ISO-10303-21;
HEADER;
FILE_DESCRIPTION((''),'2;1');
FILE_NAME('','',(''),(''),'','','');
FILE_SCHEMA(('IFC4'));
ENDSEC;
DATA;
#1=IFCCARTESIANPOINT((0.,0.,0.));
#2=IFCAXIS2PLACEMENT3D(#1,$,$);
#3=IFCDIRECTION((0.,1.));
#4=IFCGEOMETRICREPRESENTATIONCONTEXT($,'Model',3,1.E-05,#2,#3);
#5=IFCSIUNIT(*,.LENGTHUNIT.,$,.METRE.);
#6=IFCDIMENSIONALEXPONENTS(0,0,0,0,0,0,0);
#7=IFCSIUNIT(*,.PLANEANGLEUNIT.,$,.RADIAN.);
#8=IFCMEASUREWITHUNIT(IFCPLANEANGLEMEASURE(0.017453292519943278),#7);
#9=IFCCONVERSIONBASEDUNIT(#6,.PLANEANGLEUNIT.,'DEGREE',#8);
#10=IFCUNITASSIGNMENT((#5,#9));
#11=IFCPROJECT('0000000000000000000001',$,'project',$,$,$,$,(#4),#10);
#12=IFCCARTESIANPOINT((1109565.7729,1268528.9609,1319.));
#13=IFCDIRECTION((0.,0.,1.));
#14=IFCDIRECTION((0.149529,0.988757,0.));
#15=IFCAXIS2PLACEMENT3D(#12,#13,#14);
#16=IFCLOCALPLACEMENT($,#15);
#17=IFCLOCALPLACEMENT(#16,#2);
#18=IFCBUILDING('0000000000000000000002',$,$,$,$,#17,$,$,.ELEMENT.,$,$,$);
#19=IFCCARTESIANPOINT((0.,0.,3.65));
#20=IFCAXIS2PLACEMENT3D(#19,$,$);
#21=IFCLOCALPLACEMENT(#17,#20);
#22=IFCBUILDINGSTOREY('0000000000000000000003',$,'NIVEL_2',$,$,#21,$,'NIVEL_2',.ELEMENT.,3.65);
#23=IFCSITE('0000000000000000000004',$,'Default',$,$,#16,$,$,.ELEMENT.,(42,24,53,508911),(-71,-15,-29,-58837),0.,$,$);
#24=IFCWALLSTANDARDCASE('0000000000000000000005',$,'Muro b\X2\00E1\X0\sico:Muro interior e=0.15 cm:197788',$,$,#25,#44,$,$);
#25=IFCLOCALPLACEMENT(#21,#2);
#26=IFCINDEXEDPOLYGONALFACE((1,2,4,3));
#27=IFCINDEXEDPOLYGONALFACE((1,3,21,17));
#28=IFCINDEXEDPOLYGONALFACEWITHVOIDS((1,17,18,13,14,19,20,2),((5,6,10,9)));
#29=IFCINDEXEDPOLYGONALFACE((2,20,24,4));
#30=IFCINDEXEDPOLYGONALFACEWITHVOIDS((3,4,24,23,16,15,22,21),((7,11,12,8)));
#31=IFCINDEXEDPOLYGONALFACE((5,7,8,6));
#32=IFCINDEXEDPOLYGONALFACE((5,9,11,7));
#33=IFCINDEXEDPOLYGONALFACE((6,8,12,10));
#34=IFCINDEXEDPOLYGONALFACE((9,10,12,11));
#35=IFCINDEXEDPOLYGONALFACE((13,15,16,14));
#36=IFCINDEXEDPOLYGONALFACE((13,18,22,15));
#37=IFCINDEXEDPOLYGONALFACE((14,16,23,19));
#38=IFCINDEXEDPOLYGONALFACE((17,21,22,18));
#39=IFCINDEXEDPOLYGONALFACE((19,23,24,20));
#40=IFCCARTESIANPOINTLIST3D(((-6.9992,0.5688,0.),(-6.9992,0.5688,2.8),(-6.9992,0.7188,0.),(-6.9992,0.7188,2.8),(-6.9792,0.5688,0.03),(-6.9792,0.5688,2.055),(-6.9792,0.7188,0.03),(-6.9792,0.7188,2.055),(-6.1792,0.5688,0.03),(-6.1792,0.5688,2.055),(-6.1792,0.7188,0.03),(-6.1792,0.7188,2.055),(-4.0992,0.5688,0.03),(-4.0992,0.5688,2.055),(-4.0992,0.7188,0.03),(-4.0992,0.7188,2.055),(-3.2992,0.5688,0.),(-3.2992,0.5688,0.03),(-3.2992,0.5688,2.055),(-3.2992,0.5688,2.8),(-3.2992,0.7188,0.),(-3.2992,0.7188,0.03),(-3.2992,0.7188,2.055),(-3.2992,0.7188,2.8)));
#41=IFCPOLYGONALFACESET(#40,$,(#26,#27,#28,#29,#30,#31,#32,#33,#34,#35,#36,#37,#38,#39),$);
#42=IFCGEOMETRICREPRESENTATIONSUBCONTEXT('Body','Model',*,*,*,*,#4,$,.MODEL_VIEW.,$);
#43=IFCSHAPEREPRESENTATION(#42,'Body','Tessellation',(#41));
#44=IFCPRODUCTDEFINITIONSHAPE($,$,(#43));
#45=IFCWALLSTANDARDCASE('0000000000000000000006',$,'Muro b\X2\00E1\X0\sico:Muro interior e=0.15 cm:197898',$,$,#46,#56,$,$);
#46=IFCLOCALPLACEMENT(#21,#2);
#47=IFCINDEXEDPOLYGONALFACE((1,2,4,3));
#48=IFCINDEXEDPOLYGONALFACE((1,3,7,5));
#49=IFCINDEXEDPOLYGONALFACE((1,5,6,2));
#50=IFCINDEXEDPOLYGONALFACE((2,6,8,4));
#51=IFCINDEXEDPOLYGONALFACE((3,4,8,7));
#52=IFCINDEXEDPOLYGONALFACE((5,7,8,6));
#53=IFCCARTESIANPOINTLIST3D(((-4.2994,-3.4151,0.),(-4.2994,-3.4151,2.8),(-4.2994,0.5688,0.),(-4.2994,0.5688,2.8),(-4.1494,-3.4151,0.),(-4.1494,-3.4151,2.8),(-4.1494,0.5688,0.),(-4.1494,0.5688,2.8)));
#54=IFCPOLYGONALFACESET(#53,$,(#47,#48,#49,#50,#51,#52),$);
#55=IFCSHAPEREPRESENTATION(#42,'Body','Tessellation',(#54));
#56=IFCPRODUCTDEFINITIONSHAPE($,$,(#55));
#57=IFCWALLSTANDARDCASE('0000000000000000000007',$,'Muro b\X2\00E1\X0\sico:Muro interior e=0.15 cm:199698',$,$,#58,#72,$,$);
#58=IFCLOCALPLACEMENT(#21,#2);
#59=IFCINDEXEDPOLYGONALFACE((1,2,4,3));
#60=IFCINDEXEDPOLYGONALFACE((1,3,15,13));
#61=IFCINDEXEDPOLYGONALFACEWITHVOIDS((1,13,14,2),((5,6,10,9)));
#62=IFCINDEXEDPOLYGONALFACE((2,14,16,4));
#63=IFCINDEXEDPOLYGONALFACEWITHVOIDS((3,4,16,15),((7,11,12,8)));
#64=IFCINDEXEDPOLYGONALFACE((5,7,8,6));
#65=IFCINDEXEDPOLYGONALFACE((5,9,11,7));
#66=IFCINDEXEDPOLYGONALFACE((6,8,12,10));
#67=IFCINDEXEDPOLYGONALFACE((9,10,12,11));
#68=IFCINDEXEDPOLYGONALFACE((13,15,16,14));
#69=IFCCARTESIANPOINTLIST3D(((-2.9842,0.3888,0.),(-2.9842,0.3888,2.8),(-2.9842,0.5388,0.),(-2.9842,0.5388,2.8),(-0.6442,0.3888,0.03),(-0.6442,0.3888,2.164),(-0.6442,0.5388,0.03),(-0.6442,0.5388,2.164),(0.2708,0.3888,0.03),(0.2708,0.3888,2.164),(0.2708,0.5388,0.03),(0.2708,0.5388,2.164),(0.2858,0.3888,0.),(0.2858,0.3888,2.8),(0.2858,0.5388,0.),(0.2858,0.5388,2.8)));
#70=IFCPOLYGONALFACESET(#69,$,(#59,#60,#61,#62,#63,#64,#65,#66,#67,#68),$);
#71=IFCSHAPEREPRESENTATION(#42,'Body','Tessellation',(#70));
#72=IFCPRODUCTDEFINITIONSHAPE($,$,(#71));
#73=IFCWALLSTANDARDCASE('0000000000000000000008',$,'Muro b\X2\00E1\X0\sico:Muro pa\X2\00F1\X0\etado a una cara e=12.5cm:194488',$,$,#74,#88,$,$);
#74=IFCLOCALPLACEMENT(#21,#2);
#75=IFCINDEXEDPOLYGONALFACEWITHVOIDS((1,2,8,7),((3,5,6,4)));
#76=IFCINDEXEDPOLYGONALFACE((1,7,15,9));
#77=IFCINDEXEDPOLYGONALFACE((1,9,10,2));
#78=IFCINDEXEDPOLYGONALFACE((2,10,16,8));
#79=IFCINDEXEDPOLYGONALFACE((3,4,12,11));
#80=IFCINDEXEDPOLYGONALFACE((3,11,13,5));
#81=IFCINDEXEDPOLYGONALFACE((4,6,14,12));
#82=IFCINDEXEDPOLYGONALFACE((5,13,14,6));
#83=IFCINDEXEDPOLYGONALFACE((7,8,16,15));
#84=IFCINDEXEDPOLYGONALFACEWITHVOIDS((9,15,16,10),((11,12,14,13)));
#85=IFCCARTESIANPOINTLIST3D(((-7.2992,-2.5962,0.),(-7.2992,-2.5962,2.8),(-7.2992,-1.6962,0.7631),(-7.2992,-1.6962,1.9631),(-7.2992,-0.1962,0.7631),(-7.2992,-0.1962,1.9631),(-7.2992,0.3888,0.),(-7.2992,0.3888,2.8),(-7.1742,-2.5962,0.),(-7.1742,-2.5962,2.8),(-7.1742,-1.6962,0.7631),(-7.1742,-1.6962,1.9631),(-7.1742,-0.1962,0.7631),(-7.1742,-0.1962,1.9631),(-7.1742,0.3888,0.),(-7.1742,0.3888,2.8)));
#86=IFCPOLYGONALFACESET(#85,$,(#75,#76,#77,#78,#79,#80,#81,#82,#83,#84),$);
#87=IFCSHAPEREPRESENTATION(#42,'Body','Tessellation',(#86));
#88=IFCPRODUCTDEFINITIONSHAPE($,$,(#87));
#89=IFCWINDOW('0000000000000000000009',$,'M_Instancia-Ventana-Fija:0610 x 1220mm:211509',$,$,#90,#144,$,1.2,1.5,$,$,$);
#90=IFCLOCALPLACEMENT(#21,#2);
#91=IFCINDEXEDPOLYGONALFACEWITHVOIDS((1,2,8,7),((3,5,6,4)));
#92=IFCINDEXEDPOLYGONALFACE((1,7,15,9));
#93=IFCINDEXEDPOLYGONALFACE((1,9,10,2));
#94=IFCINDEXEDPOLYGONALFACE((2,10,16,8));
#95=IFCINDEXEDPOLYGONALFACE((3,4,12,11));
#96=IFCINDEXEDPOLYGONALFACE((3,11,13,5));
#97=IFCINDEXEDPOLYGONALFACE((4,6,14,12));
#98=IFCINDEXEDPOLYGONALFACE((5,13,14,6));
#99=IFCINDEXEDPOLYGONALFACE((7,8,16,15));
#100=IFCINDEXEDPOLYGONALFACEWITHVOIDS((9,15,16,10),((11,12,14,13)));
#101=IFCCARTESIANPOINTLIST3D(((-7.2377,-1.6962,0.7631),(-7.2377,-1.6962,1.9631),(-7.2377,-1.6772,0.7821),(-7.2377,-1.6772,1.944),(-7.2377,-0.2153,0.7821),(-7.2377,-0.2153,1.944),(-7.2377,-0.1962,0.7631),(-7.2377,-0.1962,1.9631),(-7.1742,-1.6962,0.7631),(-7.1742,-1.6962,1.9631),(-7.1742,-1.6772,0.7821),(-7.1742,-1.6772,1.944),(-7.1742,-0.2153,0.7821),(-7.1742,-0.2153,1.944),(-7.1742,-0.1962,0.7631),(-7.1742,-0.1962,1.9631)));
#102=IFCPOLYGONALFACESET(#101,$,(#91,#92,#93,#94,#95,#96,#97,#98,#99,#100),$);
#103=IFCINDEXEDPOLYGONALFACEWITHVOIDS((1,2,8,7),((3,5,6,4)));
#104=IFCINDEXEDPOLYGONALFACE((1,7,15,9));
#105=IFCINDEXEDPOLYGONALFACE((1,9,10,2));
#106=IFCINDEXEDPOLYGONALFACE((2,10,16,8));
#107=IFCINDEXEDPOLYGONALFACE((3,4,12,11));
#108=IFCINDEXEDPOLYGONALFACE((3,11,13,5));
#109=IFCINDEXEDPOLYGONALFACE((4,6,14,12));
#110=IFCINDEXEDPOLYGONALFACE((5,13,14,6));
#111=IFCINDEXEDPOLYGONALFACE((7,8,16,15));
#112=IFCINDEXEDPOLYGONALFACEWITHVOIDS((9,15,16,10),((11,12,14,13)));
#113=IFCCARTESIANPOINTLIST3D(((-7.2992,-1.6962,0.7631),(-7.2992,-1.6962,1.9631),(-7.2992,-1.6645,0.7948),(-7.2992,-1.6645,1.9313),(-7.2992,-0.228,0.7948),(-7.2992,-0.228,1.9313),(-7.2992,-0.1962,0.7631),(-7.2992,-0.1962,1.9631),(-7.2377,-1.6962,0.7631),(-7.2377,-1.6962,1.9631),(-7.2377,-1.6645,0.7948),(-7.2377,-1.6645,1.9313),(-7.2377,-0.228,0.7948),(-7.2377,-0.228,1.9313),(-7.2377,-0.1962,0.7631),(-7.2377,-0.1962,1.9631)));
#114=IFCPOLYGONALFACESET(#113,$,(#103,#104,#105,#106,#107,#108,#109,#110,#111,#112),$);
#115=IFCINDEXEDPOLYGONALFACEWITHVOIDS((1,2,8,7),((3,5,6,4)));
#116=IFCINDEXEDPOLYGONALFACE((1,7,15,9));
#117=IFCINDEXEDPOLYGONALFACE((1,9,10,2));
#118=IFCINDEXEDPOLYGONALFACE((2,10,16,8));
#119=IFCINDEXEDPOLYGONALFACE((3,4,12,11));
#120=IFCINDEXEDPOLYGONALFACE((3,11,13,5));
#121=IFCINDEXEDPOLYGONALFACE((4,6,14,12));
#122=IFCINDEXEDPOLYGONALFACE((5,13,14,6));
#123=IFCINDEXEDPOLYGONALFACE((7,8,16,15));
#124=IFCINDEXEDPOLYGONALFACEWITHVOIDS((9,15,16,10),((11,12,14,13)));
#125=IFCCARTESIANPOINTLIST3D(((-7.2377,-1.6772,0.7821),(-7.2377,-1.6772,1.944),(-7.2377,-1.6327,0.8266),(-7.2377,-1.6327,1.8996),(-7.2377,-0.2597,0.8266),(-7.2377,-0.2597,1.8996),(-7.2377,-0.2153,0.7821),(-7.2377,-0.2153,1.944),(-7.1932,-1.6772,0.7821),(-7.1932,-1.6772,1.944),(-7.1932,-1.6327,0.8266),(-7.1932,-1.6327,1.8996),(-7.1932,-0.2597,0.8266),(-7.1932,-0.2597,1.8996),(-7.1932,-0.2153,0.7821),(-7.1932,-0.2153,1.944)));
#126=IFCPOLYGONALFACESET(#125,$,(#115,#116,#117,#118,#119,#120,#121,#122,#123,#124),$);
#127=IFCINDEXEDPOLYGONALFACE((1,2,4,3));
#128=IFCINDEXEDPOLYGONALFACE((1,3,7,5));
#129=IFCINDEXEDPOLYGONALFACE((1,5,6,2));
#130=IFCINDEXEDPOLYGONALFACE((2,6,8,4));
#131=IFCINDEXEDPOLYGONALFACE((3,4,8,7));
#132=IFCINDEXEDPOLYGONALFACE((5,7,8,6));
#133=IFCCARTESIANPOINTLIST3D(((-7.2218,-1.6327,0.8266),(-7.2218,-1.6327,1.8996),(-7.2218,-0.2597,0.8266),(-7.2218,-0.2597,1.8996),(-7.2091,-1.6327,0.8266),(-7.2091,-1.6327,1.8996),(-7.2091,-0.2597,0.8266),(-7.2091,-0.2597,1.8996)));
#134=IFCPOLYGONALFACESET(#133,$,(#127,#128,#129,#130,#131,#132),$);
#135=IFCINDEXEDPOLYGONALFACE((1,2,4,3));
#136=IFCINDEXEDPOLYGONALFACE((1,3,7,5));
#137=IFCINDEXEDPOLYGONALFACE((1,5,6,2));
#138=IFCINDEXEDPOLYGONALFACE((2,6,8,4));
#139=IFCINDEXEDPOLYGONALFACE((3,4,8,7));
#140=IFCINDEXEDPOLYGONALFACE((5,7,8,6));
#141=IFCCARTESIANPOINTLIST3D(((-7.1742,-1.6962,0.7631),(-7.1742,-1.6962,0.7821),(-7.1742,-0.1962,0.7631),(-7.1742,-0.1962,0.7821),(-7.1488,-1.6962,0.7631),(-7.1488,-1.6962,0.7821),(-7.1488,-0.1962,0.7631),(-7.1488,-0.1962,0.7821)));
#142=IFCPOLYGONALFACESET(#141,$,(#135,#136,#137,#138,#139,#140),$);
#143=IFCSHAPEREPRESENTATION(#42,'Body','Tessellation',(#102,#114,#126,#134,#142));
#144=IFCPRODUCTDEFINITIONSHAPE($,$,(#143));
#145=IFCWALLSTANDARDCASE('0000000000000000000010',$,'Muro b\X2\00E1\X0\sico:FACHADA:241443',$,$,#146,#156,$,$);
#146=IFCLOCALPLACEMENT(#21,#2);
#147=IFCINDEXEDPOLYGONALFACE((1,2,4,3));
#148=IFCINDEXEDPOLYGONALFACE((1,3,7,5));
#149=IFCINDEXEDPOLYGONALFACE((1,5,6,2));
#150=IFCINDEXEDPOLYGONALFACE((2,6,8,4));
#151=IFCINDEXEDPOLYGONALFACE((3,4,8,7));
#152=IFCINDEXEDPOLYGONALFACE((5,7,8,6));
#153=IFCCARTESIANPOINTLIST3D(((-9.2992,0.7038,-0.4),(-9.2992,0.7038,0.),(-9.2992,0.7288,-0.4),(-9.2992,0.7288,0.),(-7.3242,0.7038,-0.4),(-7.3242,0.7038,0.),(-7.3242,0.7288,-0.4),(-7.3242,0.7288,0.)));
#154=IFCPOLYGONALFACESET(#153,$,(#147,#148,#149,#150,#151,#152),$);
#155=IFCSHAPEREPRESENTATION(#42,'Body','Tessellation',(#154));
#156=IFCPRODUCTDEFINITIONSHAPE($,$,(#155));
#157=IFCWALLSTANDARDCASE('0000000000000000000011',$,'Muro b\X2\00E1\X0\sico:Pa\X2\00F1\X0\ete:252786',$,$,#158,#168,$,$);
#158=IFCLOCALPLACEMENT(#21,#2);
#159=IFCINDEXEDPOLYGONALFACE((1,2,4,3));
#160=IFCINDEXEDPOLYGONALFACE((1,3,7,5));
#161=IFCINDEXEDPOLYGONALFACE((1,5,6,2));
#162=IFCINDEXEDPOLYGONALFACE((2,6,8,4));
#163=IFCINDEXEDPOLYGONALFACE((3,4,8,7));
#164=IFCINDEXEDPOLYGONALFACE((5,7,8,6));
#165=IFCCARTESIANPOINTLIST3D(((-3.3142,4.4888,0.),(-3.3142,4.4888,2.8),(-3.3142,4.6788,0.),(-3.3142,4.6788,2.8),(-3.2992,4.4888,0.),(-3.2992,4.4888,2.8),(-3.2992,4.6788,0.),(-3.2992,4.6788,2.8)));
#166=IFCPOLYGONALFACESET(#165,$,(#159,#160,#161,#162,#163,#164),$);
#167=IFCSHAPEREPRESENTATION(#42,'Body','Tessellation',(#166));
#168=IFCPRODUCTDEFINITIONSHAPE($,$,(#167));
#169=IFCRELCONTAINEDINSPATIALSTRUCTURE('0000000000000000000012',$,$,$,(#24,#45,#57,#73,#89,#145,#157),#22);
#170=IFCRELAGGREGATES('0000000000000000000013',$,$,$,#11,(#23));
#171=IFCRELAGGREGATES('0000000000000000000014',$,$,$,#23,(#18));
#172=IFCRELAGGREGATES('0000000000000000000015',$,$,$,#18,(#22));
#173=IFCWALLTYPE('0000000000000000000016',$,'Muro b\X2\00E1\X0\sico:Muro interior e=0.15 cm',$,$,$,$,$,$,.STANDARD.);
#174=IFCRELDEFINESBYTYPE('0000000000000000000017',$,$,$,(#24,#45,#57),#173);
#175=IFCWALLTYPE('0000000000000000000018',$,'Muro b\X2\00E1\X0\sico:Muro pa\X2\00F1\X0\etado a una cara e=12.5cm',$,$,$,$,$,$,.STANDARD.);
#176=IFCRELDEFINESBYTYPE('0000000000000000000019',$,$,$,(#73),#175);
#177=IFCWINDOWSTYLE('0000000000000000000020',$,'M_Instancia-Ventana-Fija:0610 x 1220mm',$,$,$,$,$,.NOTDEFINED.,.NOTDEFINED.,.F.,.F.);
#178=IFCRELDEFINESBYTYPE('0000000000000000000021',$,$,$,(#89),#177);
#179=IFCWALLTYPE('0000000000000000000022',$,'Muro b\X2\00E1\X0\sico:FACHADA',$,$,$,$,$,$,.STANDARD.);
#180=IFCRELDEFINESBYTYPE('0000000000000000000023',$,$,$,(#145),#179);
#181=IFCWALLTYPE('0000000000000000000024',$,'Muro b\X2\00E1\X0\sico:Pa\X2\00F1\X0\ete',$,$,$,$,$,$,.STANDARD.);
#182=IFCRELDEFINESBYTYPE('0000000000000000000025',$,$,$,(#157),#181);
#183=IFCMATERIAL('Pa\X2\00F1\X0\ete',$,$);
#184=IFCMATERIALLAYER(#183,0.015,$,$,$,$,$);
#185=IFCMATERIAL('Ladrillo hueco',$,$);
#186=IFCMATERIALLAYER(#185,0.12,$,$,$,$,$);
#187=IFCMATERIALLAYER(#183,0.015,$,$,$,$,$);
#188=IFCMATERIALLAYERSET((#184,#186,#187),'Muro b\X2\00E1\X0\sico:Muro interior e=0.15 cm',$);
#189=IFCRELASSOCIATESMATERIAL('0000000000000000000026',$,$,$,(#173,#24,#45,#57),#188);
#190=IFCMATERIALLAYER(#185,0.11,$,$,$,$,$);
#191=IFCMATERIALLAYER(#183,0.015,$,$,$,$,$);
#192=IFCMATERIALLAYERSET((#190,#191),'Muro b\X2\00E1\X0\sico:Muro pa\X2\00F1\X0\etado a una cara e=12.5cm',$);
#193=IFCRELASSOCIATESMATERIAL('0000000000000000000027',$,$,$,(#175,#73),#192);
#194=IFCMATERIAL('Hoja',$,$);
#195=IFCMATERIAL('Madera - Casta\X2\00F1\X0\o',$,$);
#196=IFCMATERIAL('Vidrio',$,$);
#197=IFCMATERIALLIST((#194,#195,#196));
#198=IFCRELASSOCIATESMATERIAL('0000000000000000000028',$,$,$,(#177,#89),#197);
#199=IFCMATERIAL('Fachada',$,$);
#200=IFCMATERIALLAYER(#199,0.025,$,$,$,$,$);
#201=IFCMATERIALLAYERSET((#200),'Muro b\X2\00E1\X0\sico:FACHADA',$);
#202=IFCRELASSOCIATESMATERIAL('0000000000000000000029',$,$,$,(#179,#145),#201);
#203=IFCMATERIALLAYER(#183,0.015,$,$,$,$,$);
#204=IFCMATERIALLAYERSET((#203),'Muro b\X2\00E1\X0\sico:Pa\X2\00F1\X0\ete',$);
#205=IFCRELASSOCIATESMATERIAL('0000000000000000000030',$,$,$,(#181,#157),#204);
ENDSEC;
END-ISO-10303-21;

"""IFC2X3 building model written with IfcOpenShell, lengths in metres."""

from ifc_helpers import new_model, entity, si_unit, converted_unit, direction, frame, frame_2d, origin, origin_2d_with_axis, place, context, subcontext, project, spatial, polyline, rectangle, outline, extrude, source, transform, mapped, material, material_list, layer, layer_set, layer_usage, type_object, type_shapes, element, fill, save


model = new_model("IFC2X3")

# Units and contexts
model_context = context("Model", 3, precision=1e-05, world=origin(), true_north=direction((0.0, 1.0)))
body_context = subcontext(model_context, "Body", "Model", "MODEL_VIEW")
ifc_project = project(units=[si_unit("LENGTHUNIT", "METRE"), converted_unit("PLANEANGLEUNIT", "DEGREE", entity("IfcPlaneAngleMeasure", 0.017453292519943278), si_unit("PLANEANGLEUNIT", "RADIAN"), dimensions=[0, 0, 0, 0, 0, 0, 0])], contexts=[model_context])

# Site, building, storey
site_placement = place(None, frame((1109565.7729, 1268528.9609, 1319.0), z_axis=(0.0, 0.0, 1.0), x_axis=(0.149529, 0.988757, 0.0)))
site = spatial("IfcSite", under=ifc_project, at=site_placement, Name="Default", CompositionType="ELEMENT", RefLatitude=(42, 24, 53, 508911), RefLongitude=(-71, -15, -29, -58837), RefElevation=0.0)
building_placement = place(site_placement, origin())
building = spatial("IfcBuilding", under=site, at=building_placement, CompositionType="ELEMENT")
storey_placement = place(building_placement, frame((0.0, 0.0, 3.65)))
storey = spatial("IfcBuildingStorey", under=building, at=storey_placement, Name="NIVEL_2", LongName="NIVEL_2", CompositionType="ELEMENT", Elevation=3.65)

# Wall, openings
ifc_material_1 = material(Name="Pañete")
ifc_layer_1 = layer(ifc_material_1, 0.015)
ifc_material_2 = material(Name="Ladrillo hueco")
ifc_layer_2 = layer(ifc_material_2, 0.12)
ifc_layer_3 = layer(ifc_material_1, 0.015)
ifc_layer_set_1 = layer_set([ifc_layer_1, ifc_layer_2, ifc_layer_3], Name="Muro básico:Muro interior e=0.15 cm")
ifc_layer_usage_1 = layer_usage(ifc_layer_set_1, "AXIS2", "NEGATIVE", 0.075)
wall_type_1 = type_object("IfcWallType", Name="Muro básico:Muro interior e=0.15 cm", PredefinedType="STANDARD", material=ifc_layer_set_1)
wall_1_placement = place(storey_placement, frame((-6.9992, 0.6438, 0.0)))
wall_1 = element("IfcWallStandardCase", 1, at=wall_1_placement, inside=storey, type_object=wall_type_1, material=ifc_layer_usage_1, Name="Muro básico:Muro interior e=0.15 cm:197788", context=body_context, shape_type="SweptSolid", body=[
    extrude(rectangle(XDim=3.7, YDim=0.15, at=frame_2d((1.85, 0.0), x_axis=(-1.0, 0.0))), origin(), (0.0, 0.0, 1.0), 2.8),
])
opening_1_placement = place(wall_1_placement, frame((2.9, -0.075, 0.03)))
element("IfcOpeningElement", 2, at=opening_1_placement, cuts=wall_1, ObjectType="Opening", context=body_context, shape_type="SweptSolid", body=[
    extrude(rectangle(XDim=2.025, YDim=0.8, at=frame_2d((1.0125, 0.4), x_axis=(1.0, 0.0))), frame((0.0, 0.0, 0.0), z_axis=(0.0, 1.0, 0.0), x_axis=(0.0, 0.0, 1.0)), (0.0, 0.0, 1.0), 0.15),
])
opening_2_placement = place(wall_1_placement, frame((0.82, 0.075, 0.03)))
element("IfcOpeningElement", 3, at=opening_2_placement, cuts=wall_1, ObjectType="Opening", context=body_context, shape_type="SweptSolid", body=[
    extrude(rectangle(XDim=2.025, YDim=0.8, at=frame_2d((1.0125, 0.4), x_axis=(1.0, 0.0))), frame((0.0, 0.0, 0.0), z_axis=(0.0, -1.0, 0.0), x_axis=(0.0, 0.0, 1.0)), (0.0, 0.0, 1.0), 0.15),
])

# Wall
ifc_layer_usage_2 = layer_usage(ifc_layer_set_1, "AXIS2", "NEGATIVE", 0.075)
wall_2_placement = place(storey_placement, frame((-4.2244, 0.5688, 0.0), z_axis=(0.0, 0.0, 1.0), x_axis=(0.0, -1.0, 0.0)))
element("IfcWallStandardCase", 4, at=wall_2_placement, inside=storey, type_object=wall_type_1, material=ifc_layer_usage_2, Name="Muro básico:Muro interior e=0.15 cm:197898", context=body_context, shape_type="SweptSolid", body=[
    extrude(rectangle(XDim=3.9839, YDim=0.15, at=frame_2d((1.992, 0.0), x_axis=(-1.0, 0.0))), origin(), (0.0, 0.0, 1.0), 2.8),
])

# Wall, opening
ifc_layer_usage_3 = layer_usage(ifc_layer_set_1, "AXIS2", "POSITIVE", -0.075)
wall_3_placement = place(storey_placement, frame((-2.9842, 0.4638, 0.0)))
wall_3 = element("IfcWallStandardCase", 5, at=wall_3_placement, inside=storey, type_object=wall_type_1, material=ifc_layer_usage_3, Name="Muro básico:Muro interior e=0.15 cm:199698", context=body_context, shape_type="SweptSolid", body=[
    extrude(rectangle(XDim=3.27, YDim=0.15, at=frame_2d((1.635, 0.0), x_axis=(-1.0, 0.0))), origin(), (0.0, 0.0, 1.0), 2.8),
])
opening_3_placement = place(wall_3_placement, frame((2.9842, -0.4638, 0.03)))
element("IfcOpeningElement", 6, at=opening_3_placement, cuts=wall_3, ObjectType="Opening", context=body_context, shape_type="SweptSolid", body=[
    extrude(rectangle(XDim=2.134, YDim=0.915, at=origin_2d_with_axis()), frame((-0.1867, -0.9852, 1.067), z_axis=(0.0, 1.0, 0.0), x_axis=(0.0, 0.0, -1.0)), (0.0, 0.0, 1.0), 3.048),
])

# Wall, opening, window
ifc_layer_4 = layer(ifc_material_2, 0.11)
ifc_layer_5 = layer(ifc_material_1, 0.015)
ifc_layer_set_2 = layer_set([ifc_layer_4, ifc_layer_5], Name="Muro básico:Muro pañetado a una cara e=12.5cm")
ifc_layer_usage_4 = layer_usage(ifc_layer_set_2, "AXIS2", "POSITIVE", -0.0625)
wall_type_2 = type_object("IfcWallType", Name="Muro básico:Muro pañetado a una cara e=12.5cm", PredefinedType="STANDARD", material=ifc_layer_set_2)
wall_4_placement = place(storey_placement, frame((-7.2367, 0.3888, 0.0), z_axis=(0.0, 0.0, 1.0), x_axis=(0.0, -1.0, 0.0)))
wall_4 = element("IfcWallStandardCase", 7, at=wall_4_placement, inside=storey, type_object=wall_type_2, material=ifc_layer_usage_4, Name="Muro básico:Muro pañetado a una cara e=12.5cm:194488", context=body_context, shape_type="SweptSolid", body=[
    extrude(rectangle(XDim=2.985, YDim=0.125, at=frame_2d((1.4925, 0.0), x_axis=(-1.0, 0.0))), origin(), (0.0, 0.0, 1.0), 2.8),
])
opening_4_placement = place(wall_4_placement, frame((0.585, -0.0625, 0.7631)))
opening_4 = element("IfcOpeningElement", 8, at=opening_4_placement, cuts=wall_4, ObjectType="Opening", context=body_context, shape_type="SweptSolid", body=[
    extrude(rectangle(XDim=1.2, YDim=1.5, at=frame_2d((0.6, 0.75), x_axis=(-1.0, 0.0))), frame((0.0, 0.0, 0.0), z_axis=(0.0, 1.0, 0.0), x_axis=(0.0, 0.0, 1.0)), (0.0, 0.0, 1.0), 0.125),
])
ifc_material_3 = material(Name="Hoja")
ifc_material_4 = material(Name="Madera - Castaño")
ifc_material_5 = material(Name="Vidrio")
ifc_material_list = material_list([ifc_material_3, ifc_material_4, ifc_material_5])
window_style = type_object("IfcWindowStyle", Name="M_Instancia-Ventana-Fija:0610 x 1220mm", ConstructionType="NOTDEFINED", OperationType="NOTDEFINED", ParameterTakesPrecedence=False, Sizeable=False, material=ifc_material_list)
shared_shape = source(origin(), body_context, "Body", "SweptSolid", [
    extrude(outline(polyline([(-0.6, -0.75), (0.6, -0.75), (0.6, 0.75), (-0.6, 0.75), (-0.6, -0.75)]), holes=[polyline([(-0.5809, -0.731), (-0.5809, 0.731), (0.581, 0.731), (0.581, -0.731), (-0.5809, -0.731)])]), frame((0.75, 0.0616, 0.6), z_axis=(0.0, 1.0, 0.0), x_axis=(0.0, 0.0, -1.0)), (0.0, 0.0, 1.0), 0.0635),
    extrude(outline(polyline([(-0.75, -0.6), (0.75, -0.6), (0.75, 0.6), (-0.75, 0.6), (-0.75, -0.6)]), holes=[polyline([(-0.7183, -0.5682), (-0.7183, 0.5683), (0.7183, 0.5683), (0.7183, -0.5682), (-0.7183, -0.5682)])]), frame((0.75, 0.0, 0.6), z_axis=(0.0, 1.0, 0.0), x_axis=(1.0, 0.0, 0.0)), (0.0, 0.0, 1.0), 0.0616),
    extrude(outline(polyline([(-0.731, -0.581), (0.731, -0.581), (0.731, 0.581), (-0.731, 0.581), (-0.731, -0.581)]), holes=[polyline([(-0.6865, -0.5365), (-0.6865, 0.5365), (0.6865, 0.5365), (0.6865, -0.5365), (-0.6865, -0.5365)])]), frame((0.75, 0.0616, 0.6), z_axis=(0.0, 1.0, 0.0), x_axis=(1.0, 0.0, 0.0)), (0.0, 0.0, 1.0), 0.0444),
    extrude(rectangle(XDim=0.0127, YDim=1.373, at=origin_2d_with_axis()), frame((0.75, 0.0838, 0.0635), z_axis=(0.0, 0.0, 1.0), x_axis=(0.0, 1.0, 0.0)), (0.0, 0.0, 1.0), 1.073),
    extrude(rectangle(XDim=0.0254, YDim=1.5, at=origin_2d_with_axis()), frame((0.75, 0.1377, 0.0), z_axis=(0.0, 0.0, 1.0), x_axis=(0.0, -1.0, 0.0)), (0.0, 0.0, 1.0), 0.019),
])
type_shapes(window_style, [shared_shape])
window_placement = place(opening_4_placement, origin())
window = element("IfcWindow", 9, at=window_placement, inside=storey, type_object=window_style, material=ifc_material_list, Name="M_Instancia-Ventana-Fija:0610 x 1220mm:211509", OverallHeight=1.2, OverallWidth=1.5, context=body_context, shape_type="MappedRepresentation", body=[
    mapped(shared_shape, transform((0.0, 0.0, 0.0), scale=1.0)),
])
fill(opening_4, window)

# Walls
ifc_material_6 = material(Name="Fachada")
ifc_layer_6 = layer(ifc_material_6, 0.025)
ifc_layer_set_3 = layer_set([ifc_layer_6], Name="Muro básico:FACHADA")
ifc_layer_usage_5 = layer_usage(ifc_layer_set_3, "AXIS2", "NEGATIVE", 0.0125)
wall_type_3 = type_object("IfcWallType", Name="Muro básico:FACHADA", PredefinedType="STANDARD", material=ifc_layer_set_3)
wall_5_placement = place(storey_placement, frame((-9.2992, 0.7163, -0.4)))
element("IfcWallStandardCase", 10, at=wall_5_placement, inside=storey, type_object=wall_type_3, material=ifc_layer_usage_5, Name="Muro básico:FACHADA:241443", context=body_context, shape_type="SweptSolid", body=[
    extrude(rectangle(XDim=1.975, YDim=0.025, at=frame_2d((0.9875, 0.0), x_axis=(-1.0, 0.0))), origin(), (0.0, 0.0, 1.0), 0.4),
])
ifc_layer_7 = layer(ifc_material_1, 0.015)
ifc_layer_set_4 = layer_set([ifc_layer_7], Name="Muro básico:Pañete")
ifc_layer_usage_6 = layer_usage(ifc_layer_set_4, "AXIS2", "POSITIVE", -0.0075)
wall_type_4 = type_object("IfcWallType", Name="Muro básico:Pañete", PredefinedType="STANDARD", material=ifc_layer_set_4)
wall_6_placement = place(storey_placement, frame((-3.3067, 4.6788, 0.0), z_axis=(0.0, 0.0, 1.0), x_axis=(0.0, -1.0, 0.0)))
element("IfcWallStandardCase", 11, at=wall_6_placement, inside=storey, type_object=wall_type_4, material=ifc_layer_usage_6, Name="Muro básico:Pañete:252786", context=body_context, shape_type="SweptSolid", body=[
    extrude(rectangle(XDim=0.19, YDim=0.015, at=frame_2d((0.095, 0.0), x_axis=(-1.0, 0.0))), origin(), (0.0, 0.0, 1.0), 2.8),
])

save(model, "model.ifc")
